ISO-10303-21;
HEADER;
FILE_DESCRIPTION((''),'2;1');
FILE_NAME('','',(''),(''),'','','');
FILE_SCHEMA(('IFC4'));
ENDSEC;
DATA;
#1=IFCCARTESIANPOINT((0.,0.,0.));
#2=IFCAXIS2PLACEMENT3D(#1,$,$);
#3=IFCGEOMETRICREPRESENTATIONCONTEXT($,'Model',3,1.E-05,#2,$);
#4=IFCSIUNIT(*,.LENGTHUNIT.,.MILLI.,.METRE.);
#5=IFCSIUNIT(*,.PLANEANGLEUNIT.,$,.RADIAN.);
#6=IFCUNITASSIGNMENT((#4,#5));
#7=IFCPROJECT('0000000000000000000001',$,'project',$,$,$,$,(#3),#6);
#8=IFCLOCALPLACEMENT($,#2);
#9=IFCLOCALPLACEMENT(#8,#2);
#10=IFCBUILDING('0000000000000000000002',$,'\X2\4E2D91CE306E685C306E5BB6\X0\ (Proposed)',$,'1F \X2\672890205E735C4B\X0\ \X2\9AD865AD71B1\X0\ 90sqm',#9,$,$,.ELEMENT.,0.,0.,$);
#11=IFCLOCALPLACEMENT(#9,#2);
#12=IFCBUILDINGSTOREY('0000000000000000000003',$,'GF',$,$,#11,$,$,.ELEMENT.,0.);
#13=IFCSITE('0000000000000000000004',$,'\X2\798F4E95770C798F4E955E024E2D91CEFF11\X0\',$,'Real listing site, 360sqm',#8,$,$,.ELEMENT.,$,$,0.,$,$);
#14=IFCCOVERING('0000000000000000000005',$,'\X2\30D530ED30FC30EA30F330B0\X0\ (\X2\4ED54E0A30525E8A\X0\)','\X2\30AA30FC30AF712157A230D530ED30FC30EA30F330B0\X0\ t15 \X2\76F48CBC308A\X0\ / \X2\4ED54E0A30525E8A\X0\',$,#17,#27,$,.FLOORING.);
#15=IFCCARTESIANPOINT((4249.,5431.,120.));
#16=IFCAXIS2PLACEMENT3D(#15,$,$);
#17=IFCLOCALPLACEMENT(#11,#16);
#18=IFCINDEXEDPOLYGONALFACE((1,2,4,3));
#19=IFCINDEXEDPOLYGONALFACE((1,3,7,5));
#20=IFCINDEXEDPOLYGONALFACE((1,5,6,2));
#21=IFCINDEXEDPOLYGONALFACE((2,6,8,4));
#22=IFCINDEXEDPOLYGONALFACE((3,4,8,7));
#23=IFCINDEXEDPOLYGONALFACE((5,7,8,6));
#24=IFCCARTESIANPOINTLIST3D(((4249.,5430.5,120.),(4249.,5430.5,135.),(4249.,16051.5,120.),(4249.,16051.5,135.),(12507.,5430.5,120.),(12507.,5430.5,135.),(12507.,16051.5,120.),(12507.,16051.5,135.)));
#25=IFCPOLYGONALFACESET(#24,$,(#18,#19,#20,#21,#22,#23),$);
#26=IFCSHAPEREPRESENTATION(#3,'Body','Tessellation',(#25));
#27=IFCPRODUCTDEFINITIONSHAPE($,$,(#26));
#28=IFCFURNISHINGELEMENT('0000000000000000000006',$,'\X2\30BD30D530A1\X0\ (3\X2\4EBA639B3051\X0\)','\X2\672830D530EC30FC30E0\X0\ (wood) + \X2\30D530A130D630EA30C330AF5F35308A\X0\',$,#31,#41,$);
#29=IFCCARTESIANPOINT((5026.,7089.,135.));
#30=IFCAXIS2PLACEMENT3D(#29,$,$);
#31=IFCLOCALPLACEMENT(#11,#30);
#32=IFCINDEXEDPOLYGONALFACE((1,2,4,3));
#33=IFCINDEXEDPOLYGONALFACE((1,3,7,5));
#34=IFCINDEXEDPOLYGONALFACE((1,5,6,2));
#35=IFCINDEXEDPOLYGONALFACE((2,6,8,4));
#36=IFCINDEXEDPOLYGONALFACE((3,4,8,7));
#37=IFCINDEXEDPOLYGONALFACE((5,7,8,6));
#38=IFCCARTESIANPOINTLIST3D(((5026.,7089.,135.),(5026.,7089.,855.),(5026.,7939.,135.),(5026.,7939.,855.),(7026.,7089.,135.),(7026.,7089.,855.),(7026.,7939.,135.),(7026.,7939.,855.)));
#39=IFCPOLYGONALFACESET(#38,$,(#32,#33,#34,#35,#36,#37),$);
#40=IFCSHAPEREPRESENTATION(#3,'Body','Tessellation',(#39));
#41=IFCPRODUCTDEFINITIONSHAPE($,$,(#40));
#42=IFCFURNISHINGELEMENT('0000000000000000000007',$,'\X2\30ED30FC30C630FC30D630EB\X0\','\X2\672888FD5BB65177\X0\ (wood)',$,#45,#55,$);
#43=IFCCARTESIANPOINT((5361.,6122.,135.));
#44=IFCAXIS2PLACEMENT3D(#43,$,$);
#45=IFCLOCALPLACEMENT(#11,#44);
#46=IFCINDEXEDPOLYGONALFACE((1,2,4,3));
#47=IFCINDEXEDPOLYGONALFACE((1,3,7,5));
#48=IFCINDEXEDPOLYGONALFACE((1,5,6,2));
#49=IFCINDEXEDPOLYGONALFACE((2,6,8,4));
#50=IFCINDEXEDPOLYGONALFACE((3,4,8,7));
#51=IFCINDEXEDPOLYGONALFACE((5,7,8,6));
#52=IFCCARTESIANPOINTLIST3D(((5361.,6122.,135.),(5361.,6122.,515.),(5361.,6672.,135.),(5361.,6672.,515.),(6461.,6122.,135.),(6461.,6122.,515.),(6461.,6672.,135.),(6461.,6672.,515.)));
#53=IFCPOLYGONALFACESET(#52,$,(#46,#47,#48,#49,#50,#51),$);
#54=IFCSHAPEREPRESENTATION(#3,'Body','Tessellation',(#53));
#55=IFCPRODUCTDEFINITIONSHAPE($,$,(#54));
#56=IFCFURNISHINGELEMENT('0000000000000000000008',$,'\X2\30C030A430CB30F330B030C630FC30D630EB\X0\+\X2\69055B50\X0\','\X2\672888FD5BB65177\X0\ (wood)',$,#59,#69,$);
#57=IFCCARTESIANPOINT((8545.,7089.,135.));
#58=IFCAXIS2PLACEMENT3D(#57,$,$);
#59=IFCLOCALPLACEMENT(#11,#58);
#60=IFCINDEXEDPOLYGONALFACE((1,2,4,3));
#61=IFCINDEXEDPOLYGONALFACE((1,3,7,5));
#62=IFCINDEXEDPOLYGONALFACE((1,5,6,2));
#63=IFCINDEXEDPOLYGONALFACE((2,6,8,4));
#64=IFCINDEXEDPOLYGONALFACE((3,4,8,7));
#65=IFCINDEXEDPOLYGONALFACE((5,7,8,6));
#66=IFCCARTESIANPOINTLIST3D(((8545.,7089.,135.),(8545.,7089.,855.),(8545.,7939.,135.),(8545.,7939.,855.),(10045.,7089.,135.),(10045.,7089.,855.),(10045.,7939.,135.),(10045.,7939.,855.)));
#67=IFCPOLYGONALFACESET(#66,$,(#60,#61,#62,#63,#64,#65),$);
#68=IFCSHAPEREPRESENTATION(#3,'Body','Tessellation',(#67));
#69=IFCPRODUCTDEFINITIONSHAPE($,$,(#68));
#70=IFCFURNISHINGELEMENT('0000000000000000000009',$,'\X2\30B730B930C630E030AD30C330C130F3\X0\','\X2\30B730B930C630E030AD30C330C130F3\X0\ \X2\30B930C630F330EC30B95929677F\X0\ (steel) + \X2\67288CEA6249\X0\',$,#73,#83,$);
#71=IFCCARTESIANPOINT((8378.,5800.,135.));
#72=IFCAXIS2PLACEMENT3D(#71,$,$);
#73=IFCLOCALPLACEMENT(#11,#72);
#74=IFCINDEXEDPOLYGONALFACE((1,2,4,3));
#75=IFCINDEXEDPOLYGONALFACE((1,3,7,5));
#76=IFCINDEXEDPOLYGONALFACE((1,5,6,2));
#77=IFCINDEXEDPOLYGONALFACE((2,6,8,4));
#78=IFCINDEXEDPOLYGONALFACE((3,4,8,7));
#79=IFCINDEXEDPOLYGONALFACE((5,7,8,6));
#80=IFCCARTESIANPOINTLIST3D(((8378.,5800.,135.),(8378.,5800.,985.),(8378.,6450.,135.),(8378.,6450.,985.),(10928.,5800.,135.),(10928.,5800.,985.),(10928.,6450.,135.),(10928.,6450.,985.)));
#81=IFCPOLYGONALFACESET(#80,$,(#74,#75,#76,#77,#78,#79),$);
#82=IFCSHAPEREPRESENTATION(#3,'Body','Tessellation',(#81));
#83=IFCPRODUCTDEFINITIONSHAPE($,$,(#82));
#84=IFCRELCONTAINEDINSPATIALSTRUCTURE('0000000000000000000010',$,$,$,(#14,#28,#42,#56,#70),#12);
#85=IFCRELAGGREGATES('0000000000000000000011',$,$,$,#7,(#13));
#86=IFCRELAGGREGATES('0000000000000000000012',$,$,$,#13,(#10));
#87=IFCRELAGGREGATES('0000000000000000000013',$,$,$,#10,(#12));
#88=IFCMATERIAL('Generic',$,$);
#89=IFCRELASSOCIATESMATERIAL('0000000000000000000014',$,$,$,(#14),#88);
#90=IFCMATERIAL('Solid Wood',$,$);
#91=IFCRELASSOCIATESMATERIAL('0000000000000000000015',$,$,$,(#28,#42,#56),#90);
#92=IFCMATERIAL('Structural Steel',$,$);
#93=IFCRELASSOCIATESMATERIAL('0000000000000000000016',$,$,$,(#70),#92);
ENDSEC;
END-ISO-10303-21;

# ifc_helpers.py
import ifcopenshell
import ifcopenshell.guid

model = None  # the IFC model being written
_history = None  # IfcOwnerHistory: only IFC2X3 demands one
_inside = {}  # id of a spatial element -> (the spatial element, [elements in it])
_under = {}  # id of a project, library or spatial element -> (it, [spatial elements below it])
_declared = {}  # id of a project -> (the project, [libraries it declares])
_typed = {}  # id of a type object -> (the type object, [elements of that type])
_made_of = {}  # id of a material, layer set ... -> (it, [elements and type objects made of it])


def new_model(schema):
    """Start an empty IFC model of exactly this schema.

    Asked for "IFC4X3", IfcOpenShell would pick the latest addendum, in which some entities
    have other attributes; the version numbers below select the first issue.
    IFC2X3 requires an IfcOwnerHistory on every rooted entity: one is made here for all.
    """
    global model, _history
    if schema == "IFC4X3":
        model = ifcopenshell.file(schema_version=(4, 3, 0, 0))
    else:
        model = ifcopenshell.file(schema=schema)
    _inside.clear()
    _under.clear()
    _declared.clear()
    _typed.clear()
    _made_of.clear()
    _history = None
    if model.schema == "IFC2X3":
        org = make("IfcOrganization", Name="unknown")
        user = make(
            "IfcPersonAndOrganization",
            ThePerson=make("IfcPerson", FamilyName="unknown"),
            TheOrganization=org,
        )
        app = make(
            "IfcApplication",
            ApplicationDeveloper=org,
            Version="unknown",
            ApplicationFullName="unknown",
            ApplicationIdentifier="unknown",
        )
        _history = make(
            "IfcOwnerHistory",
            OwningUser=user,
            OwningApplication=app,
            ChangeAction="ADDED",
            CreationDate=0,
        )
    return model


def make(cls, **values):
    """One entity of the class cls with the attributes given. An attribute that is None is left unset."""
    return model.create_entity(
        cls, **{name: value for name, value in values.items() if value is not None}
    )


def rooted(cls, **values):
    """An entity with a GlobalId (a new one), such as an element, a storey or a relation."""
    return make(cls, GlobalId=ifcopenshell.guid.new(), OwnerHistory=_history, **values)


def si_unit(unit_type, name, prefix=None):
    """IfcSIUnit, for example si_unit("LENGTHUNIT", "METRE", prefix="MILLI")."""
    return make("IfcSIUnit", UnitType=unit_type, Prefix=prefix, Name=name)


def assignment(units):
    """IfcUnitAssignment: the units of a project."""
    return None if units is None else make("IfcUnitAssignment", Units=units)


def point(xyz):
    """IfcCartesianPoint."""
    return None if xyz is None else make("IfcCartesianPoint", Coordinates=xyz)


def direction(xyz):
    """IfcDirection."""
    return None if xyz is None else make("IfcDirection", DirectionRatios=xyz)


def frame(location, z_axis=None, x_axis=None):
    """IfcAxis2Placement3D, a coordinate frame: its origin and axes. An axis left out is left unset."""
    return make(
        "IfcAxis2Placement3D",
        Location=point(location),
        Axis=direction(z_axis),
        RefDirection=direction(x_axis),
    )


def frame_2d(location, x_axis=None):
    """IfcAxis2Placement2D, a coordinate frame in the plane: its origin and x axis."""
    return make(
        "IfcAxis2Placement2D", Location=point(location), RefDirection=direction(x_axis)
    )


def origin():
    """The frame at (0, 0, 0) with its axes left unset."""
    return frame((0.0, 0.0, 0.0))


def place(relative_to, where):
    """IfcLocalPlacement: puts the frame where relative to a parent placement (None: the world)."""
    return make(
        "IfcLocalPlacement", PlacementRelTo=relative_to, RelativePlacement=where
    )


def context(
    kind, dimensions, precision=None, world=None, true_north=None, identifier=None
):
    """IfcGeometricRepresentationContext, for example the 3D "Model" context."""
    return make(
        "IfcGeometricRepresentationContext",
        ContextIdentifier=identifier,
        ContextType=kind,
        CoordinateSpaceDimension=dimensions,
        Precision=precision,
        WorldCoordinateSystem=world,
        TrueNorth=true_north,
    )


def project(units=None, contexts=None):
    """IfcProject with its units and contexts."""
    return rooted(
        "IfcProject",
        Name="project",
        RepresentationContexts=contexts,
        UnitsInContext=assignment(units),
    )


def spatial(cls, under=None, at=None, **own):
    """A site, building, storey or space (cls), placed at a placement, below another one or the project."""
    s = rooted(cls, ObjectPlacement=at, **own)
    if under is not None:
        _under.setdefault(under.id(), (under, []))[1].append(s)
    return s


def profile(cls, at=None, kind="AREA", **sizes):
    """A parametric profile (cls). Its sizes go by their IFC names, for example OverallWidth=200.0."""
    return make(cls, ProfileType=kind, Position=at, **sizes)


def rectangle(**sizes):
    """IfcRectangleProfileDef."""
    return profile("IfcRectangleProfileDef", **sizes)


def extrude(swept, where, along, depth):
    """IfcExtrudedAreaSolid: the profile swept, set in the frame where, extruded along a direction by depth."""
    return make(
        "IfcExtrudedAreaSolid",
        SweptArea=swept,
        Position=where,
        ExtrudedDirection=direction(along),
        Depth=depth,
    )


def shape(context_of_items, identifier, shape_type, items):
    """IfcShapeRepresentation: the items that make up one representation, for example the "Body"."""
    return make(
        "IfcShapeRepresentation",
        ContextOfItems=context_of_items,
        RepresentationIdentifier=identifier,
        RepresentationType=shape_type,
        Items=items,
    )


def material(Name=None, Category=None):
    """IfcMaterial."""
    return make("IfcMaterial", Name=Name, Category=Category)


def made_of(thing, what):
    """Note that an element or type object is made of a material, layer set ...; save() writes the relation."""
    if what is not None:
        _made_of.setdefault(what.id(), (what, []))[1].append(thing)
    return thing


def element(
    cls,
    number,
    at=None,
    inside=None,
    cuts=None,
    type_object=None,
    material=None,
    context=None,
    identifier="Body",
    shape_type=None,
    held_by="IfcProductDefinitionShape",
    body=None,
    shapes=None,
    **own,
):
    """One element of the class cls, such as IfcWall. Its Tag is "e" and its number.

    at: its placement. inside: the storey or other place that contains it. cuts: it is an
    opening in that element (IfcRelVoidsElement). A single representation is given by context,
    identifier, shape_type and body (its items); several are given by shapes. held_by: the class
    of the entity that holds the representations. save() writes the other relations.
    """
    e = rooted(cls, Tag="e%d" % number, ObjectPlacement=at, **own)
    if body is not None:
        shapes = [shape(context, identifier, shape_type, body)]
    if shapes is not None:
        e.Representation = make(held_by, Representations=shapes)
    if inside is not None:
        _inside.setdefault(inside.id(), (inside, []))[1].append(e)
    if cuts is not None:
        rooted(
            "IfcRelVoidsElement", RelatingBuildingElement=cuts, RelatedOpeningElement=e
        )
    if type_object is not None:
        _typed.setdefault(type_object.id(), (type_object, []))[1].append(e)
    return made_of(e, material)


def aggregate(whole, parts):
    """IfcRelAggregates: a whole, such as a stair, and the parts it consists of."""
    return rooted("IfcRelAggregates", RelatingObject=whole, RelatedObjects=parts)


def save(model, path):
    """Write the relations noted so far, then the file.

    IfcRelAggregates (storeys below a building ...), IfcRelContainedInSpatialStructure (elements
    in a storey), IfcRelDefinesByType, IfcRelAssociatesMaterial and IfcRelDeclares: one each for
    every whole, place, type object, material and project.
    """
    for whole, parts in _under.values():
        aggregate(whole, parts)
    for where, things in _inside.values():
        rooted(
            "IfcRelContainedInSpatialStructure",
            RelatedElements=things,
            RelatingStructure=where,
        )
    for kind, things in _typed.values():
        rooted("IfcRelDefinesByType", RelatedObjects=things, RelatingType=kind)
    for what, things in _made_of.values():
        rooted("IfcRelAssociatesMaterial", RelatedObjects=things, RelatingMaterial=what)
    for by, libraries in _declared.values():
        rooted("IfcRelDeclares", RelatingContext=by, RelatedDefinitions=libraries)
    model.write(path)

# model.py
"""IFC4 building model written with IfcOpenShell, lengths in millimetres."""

from ifc_helpers import new_model, si_unit, frame, frame_2d, origin, place, context, project, spatial, rectangle, extrude, material, element, save


model = new_model("IFC4")

# Units and contexts
model_context = context("Model", 3, precision=1e-05, world=origin())
ifc_project = project(units=[si_unit("LENGTHUNIT", "METRE", prefix="MILLI"), si_unit("PLANEANGLEUNIT", "RADIAN")], contexts=[model_context])

# Site, building, storey
site_placement = place(None, origin())
site = spatial("IfcSite", under=ifc_project, at=site_placement, Name="福井県福井市中野１", ObjectType="Real listing site, 360sqm", CompositionType="ELEMENT", RefElevation=0.0)
building_placement = place(site_placement, origin())
building = spatial("IfcBuilding", under=site, at=building_placement, Name="中野の桜の家 (Proposed)", ObjectType="1F 木造平屋 高断熱 90sqm", CompositionType="ELEMENT", ElevationOfRefHeight=0.0, ElevationOfTerrain=0.0)
storey_placement = place(building_placement, origin())
storey = spatial("IfcBuildingStorey", under=building, at=storey_placement, Name="GF", CompositionType="ELEMENT", Elevation=0.0)

# Shared definitions
ifc_material_1 = material(Name="Solid Wood")

# Shared definitions
ifc_material_2 = material(Name="Structural Steel")

# Covering
ifc_material_3 = material(Name="Generic")
covering_placement = place(storey_placement, frame((4249.0, 5431.0, 120.0)))
element("IfcCovering", 1, at=covering_placement, inside=storey, material=ifc_material_3, Name="フローリング (仕上げ床)", Description="オーク無垢フローリング t15 直貼り / 仕上げ床", PredefinedType="FLOORING", context=model_context, shape_type="SweptSolid", body=[
    extrude(rectangle(XDim=8258.0, YDim=10621.0, at=frame_2d((4129.0, 5310.0))), frame((4249.0, 5431.0, 120.0)), (0.0, 0.0, 1.0), 15.0),
])

# Furnishing elements
furnishing_1_placement = place(storey_placement, frame((5026.0, 7089.0, 135.0)))
element("IfcFurnishingElement", 2, at=furnishing_1_placement, inside=storey, material=ifc_material_1, Name="ソファ (3人掛け)", Description="木フレーム (wood) + ファブリック張り", context=model_context, shape_type="SweptSolid", body=[
    extrude(rectangle(XDim=2000.0, YDim=850.0, at=frame_2d((1000.0, 425.0))), frame((5026.0, 7089.0, 135.0)), (0.0, 0.0, 1.0), 720.0),
])
furnishing_2_placement = place(storey_placement, frame((5361.0, 6122.0, 135.0)))
element("IfcFurnishingElement", 3, at=furnishing_2_placement, inside=storey, material=ifc_material_1, Name="ローテーブル", Description="木製家具 (wood)", context=model_context, shape_type="SweptSolid", body=[
    extrude(rectangle(XDim=1100.0, YDim=550.0, at=frame_2d((550.0, 275.0))), frame((5361.0, 6122.0, 135.0)), (0.0, 0.0, 1.0), 380.0),
])
furnishing_3_placement = place(storey_placement, frame((8545.0, 7089.0, 135.0)))
element("IfcFurnishingElement", 4, at=furnishing_3_placement, inside=storey, material=ifc_material_1, Name="ダイニングテーブル+椅子", Description="木製家具 (wood)", context=model_context, shape_type="SweptSolid", body=[
    extrude(rectangle(XDim=1500.0, YDim=850.0, at=frame_2d((750.0, 425.0))), frame((8545.0, 7089.0, 135.0)), (0.0, 0.0, 1.0), 720.0),
])
furnishing_4_placement = place(storey_placement, frame((8378.0, 5800.0, 135.0)))
element("IfcFurnishingElement", 5, at=furnishing_4_placement, inside=storey, material=ifc_material_2, Name="システムキッチン", Description="システムキッチン ステンレス天板 (steel) + 木質扉", context=model_context, shape_type="SweptSolid", body=[
    extrude(rectangle(XDim=2550.0, YDim=650.0, at=frame_2d((1275.0, 325.0))), frame((8378.0, 5800.0, 135.0)), (0.0, 0.0, 1.0), 850.0),
])

save(model, "model.ifc")
